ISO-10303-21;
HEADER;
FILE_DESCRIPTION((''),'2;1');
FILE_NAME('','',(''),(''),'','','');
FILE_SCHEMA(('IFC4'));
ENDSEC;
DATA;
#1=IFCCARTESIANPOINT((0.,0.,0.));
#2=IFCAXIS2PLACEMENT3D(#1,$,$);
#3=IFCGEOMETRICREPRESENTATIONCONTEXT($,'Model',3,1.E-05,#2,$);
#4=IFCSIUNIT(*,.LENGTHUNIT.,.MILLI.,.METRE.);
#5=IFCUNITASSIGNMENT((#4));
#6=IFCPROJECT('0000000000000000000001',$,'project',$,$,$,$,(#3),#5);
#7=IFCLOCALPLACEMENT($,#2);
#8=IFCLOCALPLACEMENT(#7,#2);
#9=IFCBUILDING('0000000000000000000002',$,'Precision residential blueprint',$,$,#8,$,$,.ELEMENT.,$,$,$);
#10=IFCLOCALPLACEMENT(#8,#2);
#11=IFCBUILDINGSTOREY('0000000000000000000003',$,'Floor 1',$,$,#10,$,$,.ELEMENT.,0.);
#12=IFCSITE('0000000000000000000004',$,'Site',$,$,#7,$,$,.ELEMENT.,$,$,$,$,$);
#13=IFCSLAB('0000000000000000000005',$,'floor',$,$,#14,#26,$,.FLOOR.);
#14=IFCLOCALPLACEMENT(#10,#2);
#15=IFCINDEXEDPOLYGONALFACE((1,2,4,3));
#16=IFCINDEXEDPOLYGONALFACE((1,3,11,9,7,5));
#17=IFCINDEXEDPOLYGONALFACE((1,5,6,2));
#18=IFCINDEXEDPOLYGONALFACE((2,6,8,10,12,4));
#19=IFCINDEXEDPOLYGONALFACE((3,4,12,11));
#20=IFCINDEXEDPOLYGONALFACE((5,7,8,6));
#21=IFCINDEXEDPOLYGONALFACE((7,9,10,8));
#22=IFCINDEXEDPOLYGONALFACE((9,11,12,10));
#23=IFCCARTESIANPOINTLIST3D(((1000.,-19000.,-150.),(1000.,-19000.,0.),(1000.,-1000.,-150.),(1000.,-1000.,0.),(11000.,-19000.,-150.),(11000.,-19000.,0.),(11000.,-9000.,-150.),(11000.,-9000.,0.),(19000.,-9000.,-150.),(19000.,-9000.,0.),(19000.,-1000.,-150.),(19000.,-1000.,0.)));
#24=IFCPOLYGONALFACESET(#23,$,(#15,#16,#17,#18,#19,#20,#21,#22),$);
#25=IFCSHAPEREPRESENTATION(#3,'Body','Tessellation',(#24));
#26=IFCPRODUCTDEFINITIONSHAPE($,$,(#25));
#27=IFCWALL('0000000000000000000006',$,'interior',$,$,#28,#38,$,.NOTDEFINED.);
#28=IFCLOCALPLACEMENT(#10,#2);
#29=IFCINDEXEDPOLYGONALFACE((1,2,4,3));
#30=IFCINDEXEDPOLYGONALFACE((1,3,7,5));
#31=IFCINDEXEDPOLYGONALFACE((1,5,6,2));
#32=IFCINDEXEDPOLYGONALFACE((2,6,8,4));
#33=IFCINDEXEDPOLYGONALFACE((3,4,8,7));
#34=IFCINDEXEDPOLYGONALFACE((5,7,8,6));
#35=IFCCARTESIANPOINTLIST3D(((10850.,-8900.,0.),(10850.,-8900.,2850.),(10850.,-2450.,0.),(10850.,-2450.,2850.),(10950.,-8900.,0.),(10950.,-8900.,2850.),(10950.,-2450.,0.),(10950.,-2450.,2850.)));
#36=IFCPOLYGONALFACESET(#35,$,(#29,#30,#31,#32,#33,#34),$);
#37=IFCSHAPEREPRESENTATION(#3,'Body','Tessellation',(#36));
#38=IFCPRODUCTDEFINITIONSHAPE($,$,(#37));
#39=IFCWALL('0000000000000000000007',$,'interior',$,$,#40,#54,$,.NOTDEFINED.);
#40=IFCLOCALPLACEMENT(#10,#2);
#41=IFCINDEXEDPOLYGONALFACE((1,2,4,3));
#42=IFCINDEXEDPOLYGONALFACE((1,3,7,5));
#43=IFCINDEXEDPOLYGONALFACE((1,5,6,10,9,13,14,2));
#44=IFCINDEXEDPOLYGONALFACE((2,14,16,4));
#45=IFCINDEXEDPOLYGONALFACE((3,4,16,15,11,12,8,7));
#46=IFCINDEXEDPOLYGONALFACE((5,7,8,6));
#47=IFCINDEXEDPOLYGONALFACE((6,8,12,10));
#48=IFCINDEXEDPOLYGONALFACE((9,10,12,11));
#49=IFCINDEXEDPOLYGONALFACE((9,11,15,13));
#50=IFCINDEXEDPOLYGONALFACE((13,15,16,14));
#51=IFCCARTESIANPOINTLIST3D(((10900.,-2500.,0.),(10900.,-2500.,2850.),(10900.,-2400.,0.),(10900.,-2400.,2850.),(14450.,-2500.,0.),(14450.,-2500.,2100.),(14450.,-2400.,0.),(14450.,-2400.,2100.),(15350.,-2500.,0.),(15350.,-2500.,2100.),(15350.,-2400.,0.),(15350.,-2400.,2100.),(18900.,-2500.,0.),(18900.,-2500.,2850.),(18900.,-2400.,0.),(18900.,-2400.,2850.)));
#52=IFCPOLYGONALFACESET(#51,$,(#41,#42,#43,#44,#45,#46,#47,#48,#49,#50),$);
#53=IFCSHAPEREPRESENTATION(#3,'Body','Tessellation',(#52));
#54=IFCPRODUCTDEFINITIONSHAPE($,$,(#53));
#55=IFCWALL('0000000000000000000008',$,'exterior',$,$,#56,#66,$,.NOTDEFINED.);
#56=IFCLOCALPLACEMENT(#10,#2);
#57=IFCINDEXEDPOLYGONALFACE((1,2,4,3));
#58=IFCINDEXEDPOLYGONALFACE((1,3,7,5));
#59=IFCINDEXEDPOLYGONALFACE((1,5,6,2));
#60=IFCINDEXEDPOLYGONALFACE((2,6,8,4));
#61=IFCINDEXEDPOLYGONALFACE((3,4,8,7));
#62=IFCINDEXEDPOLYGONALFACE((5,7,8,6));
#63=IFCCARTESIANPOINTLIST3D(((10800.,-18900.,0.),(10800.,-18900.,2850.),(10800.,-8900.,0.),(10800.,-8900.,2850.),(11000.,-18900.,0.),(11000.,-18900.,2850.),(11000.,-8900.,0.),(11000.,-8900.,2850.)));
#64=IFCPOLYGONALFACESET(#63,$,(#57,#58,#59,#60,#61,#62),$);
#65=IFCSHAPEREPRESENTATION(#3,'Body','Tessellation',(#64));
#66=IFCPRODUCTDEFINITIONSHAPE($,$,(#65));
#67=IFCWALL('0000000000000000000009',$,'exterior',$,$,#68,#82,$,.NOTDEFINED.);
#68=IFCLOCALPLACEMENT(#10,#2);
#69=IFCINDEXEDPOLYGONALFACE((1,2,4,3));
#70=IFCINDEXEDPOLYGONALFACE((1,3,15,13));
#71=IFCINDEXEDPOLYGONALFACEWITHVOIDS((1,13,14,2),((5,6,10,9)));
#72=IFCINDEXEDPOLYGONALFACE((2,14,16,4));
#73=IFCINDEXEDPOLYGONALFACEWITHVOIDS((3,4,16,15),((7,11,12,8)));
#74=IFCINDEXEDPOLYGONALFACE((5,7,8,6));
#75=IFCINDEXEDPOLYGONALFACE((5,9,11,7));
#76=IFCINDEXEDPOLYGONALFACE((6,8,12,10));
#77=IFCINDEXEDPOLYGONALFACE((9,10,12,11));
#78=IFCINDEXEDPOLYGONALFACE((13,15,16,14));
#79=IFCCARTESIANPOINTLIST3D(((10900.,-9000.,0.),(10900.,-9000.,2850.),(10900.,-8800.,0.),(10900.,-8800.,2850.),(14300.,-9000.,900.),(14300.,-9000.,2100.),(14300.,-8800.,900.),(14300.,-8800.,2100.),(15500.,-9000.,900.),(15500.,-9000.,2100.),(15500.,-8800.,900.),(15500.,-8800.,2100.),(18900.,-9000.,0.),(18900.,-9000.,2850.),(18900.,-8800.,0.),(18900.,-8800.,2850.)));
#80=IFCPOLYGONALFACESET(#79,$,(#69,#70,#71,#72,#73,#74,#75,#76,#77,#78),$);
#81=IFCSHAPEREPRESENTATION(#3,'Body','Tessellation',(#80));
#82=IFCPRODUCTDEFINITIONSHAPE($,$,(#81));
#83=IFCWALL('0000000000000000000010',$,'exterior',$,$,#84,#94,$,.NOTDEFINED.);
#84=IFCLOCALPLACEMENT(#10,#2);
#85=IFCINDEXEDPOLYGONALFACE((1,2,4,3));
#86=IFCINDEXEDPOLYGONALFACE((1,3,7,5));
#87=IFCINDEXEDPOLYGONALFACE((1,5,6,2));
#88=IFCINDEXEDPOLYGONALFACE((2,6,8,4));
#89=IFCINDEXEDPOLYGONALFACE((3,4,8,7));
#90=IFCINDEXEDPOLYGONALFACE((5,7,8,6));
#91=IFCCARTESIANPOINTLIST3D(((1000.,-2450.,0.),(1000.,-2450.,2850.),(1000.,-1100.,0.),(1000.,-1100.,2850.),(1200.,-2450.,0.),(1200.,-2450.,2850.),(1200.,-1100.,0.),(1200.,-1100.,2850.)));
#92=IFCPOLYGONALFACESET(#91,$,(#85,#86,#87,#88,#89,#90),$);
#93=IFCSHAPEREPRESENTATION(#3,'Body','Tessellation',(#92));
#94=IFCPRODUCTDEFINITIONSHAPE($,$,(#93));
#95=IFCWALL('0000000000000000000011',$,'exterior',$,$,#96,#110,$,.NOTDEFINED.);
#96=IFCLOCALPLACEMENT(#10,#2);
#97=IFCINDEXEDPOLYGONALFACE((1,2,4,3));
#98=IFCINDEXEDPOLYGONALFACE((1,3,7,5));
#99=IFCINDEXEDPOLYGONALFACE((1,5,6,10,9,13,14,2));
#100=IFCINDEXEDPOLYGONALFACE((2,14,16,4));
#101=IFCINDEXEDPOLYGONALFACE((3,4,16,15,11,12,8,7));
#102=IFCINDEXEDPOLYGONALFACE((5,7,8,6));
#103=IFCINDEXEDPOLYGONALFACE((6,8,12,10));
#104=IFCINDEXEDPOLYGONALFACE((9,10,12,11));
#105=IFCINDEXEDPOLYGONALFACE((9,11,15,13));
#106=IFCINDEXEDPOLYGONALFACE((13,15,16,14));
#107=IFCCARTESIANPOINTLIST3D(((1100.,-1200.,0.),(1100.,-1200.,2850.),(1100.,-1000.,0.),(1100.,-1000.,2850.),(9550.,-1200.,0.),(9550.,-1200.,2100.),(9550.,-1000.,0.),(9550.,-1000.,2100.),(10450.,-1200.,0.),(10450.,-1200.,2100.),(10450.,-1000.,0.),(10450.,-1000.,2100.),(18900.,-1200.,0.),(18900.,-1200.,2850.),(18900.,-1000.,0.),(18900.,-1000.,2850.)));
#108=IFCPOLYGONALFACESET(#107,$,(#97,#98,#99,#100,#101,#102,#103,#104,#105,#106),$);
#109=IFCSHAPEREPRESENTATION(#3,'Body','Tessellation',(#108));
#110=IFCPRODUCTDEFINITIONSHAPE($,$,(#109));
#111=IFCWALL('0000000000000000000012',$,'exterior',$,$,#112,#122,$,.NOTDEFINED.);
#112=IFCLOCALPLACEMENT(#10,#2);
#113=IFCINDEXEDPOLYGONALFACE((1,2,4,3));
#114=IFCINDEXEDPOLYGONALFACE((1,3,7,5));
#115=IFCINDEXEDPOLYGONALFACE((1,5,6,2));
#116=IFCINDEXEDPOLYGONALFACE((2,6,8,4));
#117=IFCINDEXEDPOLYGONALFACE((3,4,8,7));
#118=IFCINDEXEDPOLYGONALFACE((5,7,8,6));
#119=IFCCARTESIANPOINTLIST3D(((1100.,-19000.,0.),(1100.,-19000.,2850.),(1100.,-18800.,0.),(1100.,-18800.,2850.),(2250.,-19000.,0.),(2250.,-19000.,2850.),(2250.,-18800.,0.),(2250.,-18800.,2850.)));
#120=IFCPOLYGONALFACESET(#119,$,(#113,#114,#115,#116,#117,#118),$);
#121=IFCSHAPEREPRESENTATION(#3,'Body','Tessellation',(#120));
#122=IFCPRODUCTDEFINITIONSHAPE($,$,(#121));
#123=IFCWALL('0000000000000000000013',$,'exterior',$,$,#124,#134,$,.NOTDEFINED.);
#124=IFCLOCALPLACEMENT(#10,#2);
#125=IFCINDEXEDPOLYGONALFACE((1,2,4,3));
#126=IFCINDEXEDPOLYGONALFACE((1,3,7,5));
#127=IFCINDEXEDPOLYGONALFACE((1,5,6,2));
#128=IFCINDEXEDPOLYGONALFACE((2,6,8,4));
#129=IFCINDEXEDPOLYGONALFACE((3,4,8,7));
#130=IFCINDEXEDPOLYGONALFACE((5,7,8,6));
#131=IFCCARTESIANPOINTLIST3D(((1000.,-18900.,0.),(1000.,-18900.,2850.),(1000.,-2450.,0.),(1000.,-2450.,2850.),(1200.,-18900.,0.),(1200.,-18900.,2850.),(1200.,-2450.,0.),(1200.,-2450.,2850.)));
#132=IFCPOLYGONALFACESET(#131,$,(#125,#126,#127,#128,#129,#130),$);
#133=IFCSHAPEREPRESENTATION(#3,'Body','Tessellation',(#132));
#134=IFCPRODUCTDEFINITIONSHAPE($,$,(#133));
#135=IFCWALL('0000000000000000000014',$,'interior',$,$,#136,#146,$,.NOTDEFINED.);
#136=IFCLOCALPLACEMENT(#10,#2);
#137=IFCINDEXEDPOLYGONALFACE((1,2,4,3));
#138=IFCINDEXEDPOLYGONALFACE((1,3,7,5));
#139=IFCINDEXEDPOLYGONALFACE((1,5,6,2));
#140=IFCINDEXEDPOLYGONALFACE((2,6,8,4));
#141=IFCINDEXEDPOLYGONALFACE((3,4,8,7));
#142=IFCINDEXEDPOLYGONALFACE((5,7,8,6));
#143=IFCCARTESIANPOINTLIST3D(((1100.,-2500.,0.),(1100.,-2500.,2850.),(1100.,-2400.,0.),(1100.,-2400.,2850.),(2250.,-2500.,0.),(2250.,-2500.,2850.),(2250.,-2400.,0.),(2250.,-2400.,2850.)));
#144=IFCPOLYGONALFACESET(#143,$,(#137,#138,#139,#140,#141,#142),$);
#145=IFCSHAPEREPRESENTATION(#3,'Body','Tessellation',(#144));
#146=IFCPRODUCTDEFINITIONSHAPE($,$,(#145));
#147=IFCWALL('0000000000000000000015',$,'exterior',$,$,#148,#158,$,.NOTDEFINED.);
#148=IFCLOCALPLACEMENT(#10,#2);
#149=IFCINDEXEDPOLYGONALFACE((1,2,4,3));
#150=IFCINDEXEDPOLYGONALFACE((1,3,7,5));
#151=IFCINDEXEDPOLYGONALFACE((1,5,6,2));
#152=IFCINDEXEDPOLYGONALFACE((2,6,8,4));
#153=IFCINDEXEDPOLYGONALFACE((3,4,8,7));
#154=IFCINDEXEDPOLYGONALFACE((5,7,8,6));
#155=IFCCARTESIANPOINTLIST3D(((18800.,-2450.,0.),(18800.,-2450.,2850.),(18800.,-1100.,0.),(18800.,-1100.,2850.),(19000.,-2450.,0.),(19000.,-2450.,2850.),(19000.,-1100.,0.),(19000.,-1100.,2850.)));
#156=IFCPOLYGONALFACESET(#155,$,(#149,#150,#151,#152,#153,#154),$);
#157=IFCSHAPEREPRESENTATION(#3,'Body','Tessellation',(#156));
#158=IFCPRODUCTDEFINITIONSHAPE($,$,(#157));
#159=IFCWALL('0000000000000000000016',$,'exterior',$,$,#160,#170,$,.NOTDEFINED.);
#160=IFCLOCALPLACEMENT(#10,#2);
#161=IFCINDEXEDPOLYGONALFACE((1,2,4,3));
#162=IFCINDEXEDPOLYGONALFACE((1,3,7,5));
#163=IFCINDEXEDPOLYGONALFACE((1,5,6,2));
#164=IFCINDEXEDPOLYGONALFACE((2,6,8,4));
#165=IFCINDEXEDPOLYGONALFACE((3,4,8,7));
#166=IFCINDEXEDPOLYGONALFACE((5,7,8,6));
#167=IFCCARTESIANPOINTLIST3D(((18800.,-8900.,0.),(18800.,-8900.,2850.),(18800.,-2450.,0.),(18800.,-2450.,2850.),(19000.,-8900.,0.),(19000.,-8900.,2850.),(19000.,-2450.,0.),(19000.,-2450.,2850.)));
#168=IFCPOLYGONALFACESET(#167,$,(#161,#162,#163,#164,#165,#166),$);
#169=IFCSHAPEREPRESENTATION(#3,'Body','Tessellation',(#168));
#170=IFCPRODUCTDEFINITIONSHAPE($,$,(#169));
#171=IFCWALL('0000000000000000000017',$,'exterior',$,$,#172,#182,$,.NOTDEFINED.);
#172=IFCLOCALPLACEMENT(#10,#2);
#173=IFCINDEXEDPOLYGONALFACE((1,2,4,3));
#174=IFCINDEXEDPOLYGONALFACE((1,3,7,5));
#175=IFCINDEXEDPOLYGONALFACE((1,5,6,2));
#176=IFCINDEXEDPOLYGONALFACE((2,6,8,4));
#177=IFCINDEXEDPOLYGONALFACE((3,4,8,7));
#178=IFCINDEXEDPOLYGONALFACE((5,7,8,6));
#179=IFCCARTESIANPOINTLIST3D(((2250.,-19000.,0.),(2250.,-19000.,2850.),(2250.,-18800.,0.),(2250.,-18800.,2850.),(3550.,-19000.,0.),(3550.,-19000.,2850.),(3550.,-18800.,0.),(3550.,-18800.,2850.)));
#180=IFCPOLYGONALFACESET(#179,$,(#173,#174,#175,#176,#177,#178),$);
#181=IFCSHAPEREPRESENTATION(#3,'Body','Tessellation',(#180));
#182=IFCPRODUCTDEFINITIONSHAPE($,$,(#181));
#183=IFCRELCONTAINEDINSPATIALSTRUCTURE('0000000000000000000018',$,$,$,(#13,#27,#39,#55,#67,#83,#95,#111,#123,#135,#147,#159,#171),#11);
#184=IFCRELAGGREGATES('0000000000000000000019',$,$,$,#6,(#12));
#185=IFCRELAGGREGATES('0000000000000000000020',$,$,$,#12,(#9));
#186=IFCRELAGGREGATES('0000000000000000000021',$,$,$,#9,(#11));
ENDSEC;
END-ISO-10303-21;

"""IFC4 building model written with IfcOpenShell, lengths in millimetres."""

from ifc_helpers import new_model, si_unit, frame, origin, place, context, project, spatial, polyline, outline, extrude, element, save


model = new_model("IFC4")

# Units and contexts
model_context = context("Model", 3, precision=1e-05, world=origin())
ifc_project = project(units=[si_unit("LENGTHUNIT", "METRE", prefix="MILLI")], contexts=[model_context])

# Site, building, storey
site_placement = place(None, origin())
site = spatial("IfcSite", under=ifc_project, at=site_placement, Name="Site", CompositionType="ELEMENT")
building_placement = place(site_placement, origin())
building = spatial("IfcBuilding", under=site, at=building_placement, Name="Precision residential blueprint", CompositionType="ELEMENT")
storey_placement = place(building_placement, origin())
storey = spatial("IfcBuildingStorey", under=building, at=storey_placement, Name="Floor 1", CompositionType="ELEMENT", Elevation=0.0)

# Slab
slab_placement = place(storey_placement, origin())
element("IfcSlab", 1, at=slab_placement, inside=storey, Name="floor", PredefinedType="FLOOR", context=model_context, shape_type="SweptSolid", body=[
    extrude(outline(polyline([(1000.0, -19000.0), (11000.0, -19000.0), (11000.0, -9000.0), (19000.0, -9000.0), (19000.0, -1000.0), (1000.0, -1000.0), (1000.0, -19000.0)])), frame((0.0, 0.0, -150.0)), (0.0, 0.0, 1.0), 150.0),
])

# Wall
wall_1_placement = place(storey_placement, origin())
element("IfcWall", 2, at=wall_1_placement, inside=storey, Name="interior", PredefinedType="NOTDEFINED", context=model_context, shape_type="SweptSolid", body=[
    extrude(outline(polyline([(10950.0, -2450.0), (10950.0, -8900.0), (10850.0, -8900.0), (10850.0, -2450.0), (10950.0, -2450.0)])), origin(), (0.0, 0.0, 1.0), 2850.0),
])

# Wall, opening
wall_2_placement = place(storey_placement, origin())
wall_2 = element("IfcWall", 3, at=wall_2_placement, inside=storey, Name="interior", PredefinedType="NOTDEFINED", context=model_context, shape_type="SweptSolid", body=[
    extrude(outline(polyline([(10900.0, -2400.0), (18900.0, -2400.0), (18900.0, -2500.0), (10900.0, -2500.0), (10900.0, -2400.0)])), origin(), (0.0, 0.0, 1.0), 2850.0),
])
opening_1_placement = place(storey_placement, origin())
element("IfcOpeningElement", 4, at=opening_1_placement, cuts=wall_2, PredefinedType="OPENING", context=model_context, shape_type="SweptSolid", body=[
    extrude(outline(polyline([(14450.0, -2400.0), (15350.0, -2400.0), (15350.0, -2500.0), (14450.0, -2500.0), (14450.0, -2400.0)])), origin(), (0.0, 0.0, 1.0), 2100.0),
])

# Wall
wall_3_placement = place(storey_placement, origin())
element("IfcWall", 5, at=wall_3_placement, inside=storey, Name="exterior", PredefinedType="NOTDEFINED", context=model_context, shape_type="SweptSolid", body=[
    extrude(outline(polyline([(11000.0, -8900.0), (11000.0, -18900.0), (10800.0, -18900.0), (10800.0, -8900.0), (11000.0, -8900.0)])), origin(), (0.0, 0.0, 1.0), 2850.0),
])

# Wall, opening
wall_4_placement = place(storey_placement, origin())
wall_4 = element("IfcWall", 6, at=wall_4_placement, inside=storey, Name="exterior", PredefinedType="NOTDEFINED", context=model_context, shape_type="SweptSolid", body=[
    extrude(outline(polyline([(10900.0, -8800.0), (18900.0, -8800.0), (18900.0, -9000.0), (10900.0, -9000.0), (10900.0, -8800.0)])), origin(), (0.0, 0.0, 1.0), 2850.0),
])
opening_2_placement = place(storey_placement, origin())
element("IfcOpeningElement", 7, at=opening_2_placement, cuts=wall_4, PredefinedType="OPENING", context=model_context, shape_type="SweptSolid", body=[
    extrude(outline(polyline([(14300.0, -8800.0), (15500.0, -8800.0), (15500.0, -9000.0), (14300.0, -9000.0), (14300.0, -8800.0)])), frame((0.0, 0.0, 900.0)), (0.0, 0.0, 1.0), 1200.0),
])

# Wall
wall_5_placement = place(storey_placement, origin())
element("IfcWall", 8, at=wall_5_placement, inside=storey, Name="exterior", PredefinedType="NOTDEFINED", context=model_context, shape_type="SweptSolid", body=[
    extrude(outline(polyline([(1200.0, -1100.0), (1200.0, -2450.0), (1000.0, -2450.0), (1000.0, -1100.0), (1200.0, -1100.0)])), origin(), (0.0, 0.0, 1.0), 2850.0),
])

# Wall, opening
wall_6_placement = place(storey_placement, origin())
wall_6 = element("IfcWall", 9, at=wall_6_placement, inside=storey, Name="exterior", PredefinedType="NOTDEFINED", context=model_context, shape_type="SweptSolid", body=[
    extrude(outline(polyline([(1100.0, -1000.0), (18900.0, -1000.0), (18900.0, -1200.0), (1100.0, -1200.0), (1100.0, -1000.0)])), origin(), (0.0, 0.0, 1.0), 2850.0),
])
opening_3_placement = place(storey_placement, origin())
element("IfcOpeningElement", 10, at=opening_3_placement, cuts=wall_6, PredefinedType="OPENING", context=model_context, shape_type="SweptSolid", body=[
    extrude(outline(polyline([(9550.0, -1000.0), (10450.0, -1000.0), (10450.0, -1200.0), (9550.0, -1200.0), (9550.0, -1000.0)])), origin(), (0.0, 0.0, 1.0), 2100.0),
])

# Walls
wall_7_placement = place(storey_placement, origin())
element("IfcWall", 11, at=wall_7_placement, inside=storey, Name="exterior", PredefinedType="NOTDEFINED", context=model_context, shape_type="SweptSolid", body=[
    extrude(outline(polyline([(1100.0, -18800.0), (2250.0, -18800.0), (2250.0, -19000.0), (1100.0, -19000.0), (1100.0, -18800.0)])), origin(), (0.0, 0.0, 1.0), 2850.0),
])
wall_8_placement = place(storey_placement, origin())
element("IfcWall", 12, at=wall_8_placement, inside=storey, Name="exterior", PredefinedType="NOTDEFINED", context=model_context, shape_type="SweptSolid", body=[
    extrude(outline(polyline([(1200.0, -2450.0), (1200.0, -18900.0), (1000.0, -18900.0), (1000.0, -2450.0), (1200.0, -2450.0)])), origin(), (0.0, 0.0, 1.0), 2850.0),
])
wall_9_placement = place(storey_placement, origin())
element("IfcWall", 13, at=wall_9_placement, inside=storey, Name="interior", PredefinedType="NOTDEFINED", context=model_context, shape_type="SweptSolid", body=[
    extrude(outline(polyline([(1100.0, -2400.0), (2250.0, -2400.0), (2250.0, -2500.0), (1100.0, -2500.0), (1100.0, -2400.0)])), origin(), (0.0, 0.0, 1.0), 2850.0),
])
wall_10_placement = place(storey_placement, origin())
element("IfcWall", 14, at=wall_10_placement, inside=storey, Name="exterior", PredefinedType="NOTDEFINED", context=model_context, shape_type="SweptSolid", body=[
    extrude(outline(polyline([(19000.0, -1100.0), (19000.0, -2450.0), (18800.0, -2450.0), (18800.0, -1100.0), (19000.0, -1100.0)])), origin(), (0.0, 0.0, 1.0), 2850.0),
])
wall_11_placement = place(storey_placement, origin())
element("IfcWall", 15, at=wall_11_placement, inside=storey, Name="exterior", PredefinedType="NOTDEFINED", context=model_context, shape_type="SweptSolid", body=[
    extrude(outline(polyline([(19000.0, -2450.0), (19000.0, -8900.0), (18800.0, -8900.0), (18800.0, -2450.0), (19000.0, -2450.0)])), origin(), (0.0, 0.0, 1.0), 2850.0),
])
wall_12_placement = place(storey_placement, origin())
element("IfcWall", 16, at=wall_12_placement, inside=storey, Name="exterior", PredefinedType="NOTDEFINED", context=model_context, shape_type="SweptSolid", body=[
    extrude(outline(polyline([(2250.0, -18800.0), (3550.0, -18800.0), (3550.0, -19000.0), (2250.0, -19000.0), (2250.0, -18800.0)])), origin(), (0.0, 0.0, 1.0), 2850.0),
])

save(model, "model.ifc")
